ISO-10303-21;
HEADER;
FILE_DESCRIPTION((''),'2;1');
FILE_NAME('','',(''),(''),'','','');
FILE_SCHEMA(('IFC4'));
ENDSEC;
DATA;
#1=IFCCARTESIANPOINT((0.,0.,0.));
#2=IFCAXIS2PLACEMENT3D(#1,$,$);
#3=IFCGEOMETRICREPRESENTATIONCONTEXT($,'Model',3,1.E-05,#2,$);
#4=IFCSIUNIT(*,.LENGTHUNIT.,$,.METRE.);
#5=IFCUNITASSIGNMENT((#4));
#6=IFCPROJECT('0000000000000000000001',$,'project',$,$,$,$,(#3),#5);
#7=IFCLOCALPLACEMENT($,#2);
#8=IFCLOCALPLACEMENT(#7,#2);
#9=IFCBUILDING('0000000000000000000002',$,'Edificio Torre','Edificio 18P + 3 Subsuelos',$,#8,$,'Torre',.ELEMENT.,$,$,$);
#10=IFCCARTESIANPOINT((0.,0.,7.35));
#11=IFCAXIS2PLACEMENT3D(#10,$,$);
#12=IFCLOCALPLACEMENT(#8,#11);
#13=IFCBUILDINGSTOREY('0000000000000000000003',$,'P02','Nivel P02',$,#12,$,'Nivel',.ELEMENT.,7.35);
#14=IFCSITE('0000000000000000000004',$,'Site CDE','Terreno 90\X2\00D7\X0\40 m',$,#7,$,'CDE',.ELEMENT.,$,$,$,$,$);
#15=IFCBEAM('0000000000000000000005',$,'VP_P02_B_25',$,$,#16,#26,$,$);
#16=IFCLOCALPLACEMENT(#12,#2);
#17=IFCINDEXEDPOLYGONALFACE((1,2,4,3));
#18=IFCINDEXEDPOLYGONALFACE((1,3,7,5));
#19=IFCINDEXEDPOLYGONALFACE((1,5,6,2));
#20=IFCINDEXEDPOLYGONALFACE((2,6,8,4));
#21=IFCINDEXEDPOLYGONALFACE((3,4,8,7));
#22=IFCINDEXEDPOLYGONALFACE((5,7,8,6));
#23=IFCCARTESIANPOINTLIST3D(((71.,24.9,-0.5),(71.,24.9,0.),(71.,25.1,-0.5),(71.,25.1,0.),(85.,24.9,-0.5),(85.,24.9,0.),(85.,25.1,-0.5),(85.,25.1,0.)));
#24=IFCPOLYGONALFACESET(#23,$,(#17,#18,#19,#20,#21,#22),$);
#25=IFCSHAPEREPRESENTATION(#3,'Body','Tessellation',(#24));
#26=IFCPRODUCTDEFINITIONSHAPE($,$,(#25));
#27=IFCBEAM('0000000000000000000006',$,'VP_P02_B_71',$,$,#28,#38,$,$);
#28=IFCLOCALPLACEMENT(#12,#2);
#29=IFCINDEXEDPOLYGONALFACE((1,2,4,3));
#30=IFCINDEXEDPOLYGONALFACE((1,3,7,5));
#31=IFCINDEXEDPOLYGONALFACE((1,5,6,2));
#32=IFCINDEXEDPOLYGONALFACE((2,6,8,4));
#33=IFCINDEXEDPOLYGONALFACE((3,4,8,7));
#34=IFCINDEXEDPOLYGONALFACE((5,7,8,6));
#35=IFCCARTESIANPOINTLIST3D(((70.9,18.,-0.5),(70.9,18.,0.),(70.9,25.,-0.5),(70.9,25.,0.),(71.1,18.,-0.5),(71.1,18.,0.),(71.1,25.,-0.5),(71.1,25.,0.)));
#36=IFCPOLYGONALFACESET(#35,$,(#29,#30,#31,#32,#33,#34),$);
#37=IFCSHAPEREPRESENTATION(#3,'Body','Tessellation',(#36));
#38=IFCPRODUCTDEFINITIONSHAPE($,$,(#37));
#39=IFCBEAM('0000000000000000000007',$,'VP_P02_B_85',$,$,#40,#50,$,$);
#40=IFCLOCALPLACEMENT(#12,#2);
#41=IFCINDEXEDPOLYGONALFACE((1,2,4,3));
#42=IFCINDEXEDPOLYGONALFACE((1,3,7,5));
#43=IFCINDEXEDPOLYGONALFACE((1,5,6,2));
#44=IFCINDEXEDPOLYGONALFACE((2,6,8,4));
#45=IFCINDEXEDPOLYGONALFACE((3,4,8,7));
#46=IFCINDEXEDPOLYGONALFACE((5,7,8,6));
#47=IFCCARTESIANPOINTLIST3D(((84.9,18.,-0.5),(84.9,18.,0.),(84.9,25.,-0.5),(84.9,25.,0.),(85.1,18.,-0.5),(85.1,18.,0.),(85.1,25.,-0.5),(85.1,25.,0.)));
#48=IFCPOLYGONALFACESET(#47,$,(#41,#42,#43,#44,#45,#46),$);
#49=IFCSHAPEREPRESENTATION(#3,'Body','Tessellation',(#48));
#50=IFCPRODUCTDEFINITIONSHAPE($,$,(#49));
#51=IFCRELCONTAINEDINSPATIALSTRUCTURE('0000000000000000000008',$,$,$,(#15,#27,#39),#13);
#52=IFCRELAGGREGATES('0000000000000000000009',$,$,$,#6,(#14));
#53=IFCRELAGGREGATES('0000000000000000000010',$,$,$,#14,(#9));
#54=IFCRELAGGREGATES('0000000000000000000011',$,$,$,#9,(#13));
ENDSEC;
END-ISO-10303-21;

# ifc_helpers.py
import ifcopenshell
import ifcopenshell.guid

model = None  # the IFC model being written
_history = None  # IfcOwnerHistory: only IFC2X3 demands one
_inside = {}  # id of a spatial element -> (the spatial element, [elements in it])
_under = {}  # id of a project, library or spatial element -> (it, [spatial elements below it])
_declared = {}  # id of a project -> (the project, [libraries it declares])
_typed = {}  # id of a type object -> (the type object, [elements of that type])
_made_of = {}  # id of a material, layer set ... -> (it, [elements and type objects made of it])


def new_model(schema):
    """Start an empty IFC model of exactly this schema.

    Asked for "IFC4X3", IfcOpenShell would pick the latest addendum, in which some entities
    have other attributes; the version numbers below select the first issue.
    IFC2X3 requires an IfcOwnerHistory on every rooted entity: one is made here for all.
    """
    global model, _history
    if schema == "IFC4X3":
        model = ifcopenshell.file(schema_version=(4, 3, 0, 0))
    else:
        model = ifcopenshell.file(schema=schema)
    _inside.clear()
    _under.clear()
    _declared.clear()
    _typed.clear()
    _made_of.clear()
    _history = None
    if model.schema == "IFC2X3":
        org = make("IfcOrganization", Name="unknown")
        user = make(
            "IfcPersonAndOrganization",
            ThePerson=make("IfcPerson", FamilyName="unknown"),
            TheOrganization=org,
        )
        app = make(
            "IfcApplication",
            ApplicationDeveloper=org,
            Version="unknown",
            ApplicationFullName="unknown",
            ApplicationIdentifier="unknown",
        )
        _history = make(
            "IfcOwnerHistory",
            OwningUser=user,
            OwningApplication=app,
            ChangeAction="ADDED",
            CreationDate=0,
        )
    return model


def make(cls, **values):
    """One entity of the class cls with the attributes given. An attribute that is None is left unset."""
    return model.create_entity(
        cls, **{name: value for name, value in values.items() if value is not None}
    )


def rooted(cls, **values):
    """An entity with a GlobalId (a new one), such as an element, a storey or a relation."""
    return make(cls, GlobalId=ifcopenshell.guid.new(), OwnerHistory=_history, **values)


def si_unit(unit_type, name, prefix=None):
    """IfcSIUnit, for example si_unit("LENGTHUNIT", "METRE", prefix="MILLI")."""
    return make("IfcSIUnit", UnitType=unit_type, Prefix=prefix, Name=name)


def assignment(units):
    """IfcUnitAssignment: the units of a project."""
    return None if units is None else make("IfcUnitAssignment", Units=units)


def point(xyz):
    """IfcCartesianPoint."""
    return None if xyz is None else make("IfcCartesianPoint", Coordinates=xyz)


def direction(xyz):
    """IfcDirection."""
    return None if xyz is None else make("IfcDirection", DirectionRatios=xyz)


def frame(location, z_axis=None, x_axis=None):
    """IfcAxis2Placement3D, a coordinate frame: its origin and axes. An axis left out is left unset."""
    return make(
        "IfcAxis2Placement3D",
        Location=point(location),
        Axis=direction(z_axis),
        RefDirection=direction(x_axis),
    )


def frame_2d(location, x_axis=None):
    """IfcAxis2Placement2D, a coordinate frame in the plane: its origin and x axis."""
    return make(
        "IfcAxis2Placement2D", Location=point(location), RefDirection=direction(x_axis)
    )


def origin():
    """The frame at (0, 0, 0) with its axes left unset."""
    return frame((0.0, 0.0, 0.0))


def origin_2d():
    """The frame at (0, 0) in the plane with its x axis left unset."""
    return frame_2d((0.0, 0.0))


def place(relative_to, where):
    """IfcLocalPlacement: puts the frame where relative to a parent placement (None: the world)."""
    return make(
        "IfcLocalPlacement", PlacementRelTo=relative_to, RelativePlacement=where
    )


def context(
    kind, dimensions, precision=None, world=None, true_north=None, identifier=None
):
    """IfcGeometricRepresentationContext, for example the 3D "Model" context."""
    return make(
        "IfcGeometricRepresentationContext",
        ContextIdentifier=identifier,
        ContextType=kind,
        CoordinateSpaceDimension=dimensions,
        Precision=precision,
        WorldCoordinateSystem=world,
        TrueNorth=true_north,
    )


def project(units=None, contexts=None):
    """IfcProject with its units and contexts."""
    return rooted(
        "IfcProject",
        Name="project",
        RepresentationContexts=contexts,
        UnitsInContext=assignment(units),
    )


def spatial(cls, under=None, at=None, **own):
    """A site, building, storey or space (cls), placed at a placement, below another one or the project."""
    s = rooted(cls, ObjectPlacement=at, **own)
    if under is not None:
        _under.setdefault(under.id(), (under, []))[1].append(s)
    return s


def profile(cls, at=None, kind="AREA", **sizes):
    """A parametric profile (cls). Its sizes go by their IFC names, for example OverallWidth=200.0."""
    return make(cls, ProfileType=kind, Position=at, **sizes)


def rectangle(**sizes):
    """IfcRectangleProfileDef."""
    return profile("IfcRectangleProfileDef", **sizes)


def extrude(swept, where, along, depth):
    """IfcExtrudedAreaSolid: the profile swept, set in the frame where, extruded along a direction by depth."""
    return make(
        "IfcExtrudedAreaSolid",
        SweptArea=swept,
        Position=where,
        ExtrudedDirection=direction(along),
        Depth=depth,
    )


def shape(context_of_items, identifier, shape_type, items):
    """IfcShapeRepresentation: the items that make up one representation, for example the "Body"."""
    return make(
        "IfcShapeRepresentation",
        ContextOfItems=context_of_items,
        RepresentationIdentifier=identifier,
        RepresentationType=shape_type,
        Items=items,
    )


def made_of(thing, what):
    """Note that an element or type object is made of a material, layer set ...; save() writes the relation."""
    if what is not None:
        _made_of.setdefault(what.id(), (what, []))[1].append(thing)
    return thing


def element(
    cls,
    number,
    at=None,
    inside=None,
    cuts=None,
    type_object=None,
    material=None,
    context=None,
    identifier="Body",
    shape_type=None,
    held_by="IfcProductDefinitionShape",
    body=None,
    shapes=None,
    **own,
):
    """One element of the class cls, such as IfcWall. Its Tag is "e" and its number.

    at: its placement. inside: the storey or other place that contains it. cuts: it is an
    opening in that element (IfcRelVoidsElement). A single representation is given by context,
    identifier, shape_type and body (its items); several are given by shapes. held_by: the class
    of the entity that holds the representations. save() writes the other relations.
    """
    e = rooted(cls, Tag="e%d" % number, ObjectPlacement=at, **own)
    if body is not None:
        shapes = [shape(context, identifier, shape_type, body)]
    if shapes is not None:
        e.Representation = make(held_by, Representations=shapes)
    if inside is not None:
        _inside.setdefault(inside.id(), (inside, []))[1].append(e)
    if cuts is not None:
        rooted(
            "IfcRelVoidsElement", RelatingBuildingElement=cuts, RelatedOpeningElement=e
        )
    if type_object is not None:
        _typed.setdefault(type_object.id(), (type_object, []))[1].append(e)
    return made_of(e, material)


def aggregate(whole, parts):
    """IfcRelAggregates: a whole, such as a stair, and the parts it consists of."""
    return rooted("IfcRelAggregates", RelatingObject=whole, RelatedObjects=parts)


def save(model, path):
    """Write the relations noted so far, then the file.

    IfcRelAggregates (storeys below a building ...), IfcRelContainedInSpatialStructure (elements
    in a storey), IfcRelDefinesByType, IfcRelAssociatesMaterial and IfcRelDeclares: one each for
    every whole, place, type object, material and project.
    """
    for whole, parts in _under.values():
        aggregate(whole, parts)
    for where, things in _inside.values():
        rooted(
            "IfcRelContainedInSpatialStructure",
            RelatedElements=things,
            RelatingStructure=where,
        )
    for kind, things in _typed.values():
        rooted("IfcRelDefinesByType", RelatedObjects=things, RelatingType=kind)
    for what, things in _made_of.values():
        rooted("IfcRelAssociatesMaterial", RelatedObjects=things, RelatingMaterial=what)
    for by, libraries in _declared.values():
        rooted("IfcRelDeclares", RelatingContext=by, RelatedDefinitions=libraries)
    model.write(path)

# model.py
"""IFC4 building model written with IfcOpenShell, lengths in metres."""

from ifc_helpers import new_model, si_unit, frame, origin, origin_2d, place, context, project, spatial, rectangle, extrude, element, save


model = new_model("IFC4")

# Units and contexts
model_context = context("Model", 3, precision=1e-05, world=origin())
ifc_project = project(units=[si_unit("LENGTHUNIT", "METRE")], contexts=[model_context])

# Site, building, storey
site_placement = place(None, origin())
site = spatial("IfcSite", under=ifc_project, at=site_placement, Name="Site CDE", Description="Terreno 90×40 m", LongName="CDE", CompositionType="ELEMENT")
building_placement = place(site_placement, origin())
building = spatial("IfcBuilding", under=site, at=building_placement, Name="Edificio Torre", Description="Edificio 18P + 3 Subsuelos", LongName="Torre", CompositionType="ELEMENT")
storey_placement = place(building_placement, frame((0.0, 0.0, 7.35)))
storey = spatial("IfcBuildingStorey", under=building, at=storey_placement, Name="P02", Description="Nivel P02", LongName="Nivel", CompositionType="ELEMENT", Elevation=7.35)

# Beams
for number, where, name in (
    (1, (78.0, 25.0, -0.5), "VP_P02_B_25"),
):
    element("IfcBeam", number, at=place(storey_placement, frame(where)), inside=storey, Name=name, context=model_context, shape_type="SweptSolid", body=[
        extrude(rectangle(XDim=14.0, YDim=0.2, at=origin_2d()), origin(), (0.0, 0.0, 1.0), 0.5),
    ])
for number, where, name in (
    (2, (71.0, 21.5, -0.5), "VP_P02_B_71"),
    (3, (85.0, 21.5, -0.5), "VP_P02_B_85"),
):
    element("IfcBeam", number, at=place(storey_placement, frame(where)), inside=storey, Name=name, context=model_context, shape_type="SweptSolid", body=[
        extrude(rectangle(XDim=0.2, YDim=7.0, at=origin_2d()), origin(), (0.0, 0.0, 1.0), 0.5),
    ])

save(model, "model.ifc")
